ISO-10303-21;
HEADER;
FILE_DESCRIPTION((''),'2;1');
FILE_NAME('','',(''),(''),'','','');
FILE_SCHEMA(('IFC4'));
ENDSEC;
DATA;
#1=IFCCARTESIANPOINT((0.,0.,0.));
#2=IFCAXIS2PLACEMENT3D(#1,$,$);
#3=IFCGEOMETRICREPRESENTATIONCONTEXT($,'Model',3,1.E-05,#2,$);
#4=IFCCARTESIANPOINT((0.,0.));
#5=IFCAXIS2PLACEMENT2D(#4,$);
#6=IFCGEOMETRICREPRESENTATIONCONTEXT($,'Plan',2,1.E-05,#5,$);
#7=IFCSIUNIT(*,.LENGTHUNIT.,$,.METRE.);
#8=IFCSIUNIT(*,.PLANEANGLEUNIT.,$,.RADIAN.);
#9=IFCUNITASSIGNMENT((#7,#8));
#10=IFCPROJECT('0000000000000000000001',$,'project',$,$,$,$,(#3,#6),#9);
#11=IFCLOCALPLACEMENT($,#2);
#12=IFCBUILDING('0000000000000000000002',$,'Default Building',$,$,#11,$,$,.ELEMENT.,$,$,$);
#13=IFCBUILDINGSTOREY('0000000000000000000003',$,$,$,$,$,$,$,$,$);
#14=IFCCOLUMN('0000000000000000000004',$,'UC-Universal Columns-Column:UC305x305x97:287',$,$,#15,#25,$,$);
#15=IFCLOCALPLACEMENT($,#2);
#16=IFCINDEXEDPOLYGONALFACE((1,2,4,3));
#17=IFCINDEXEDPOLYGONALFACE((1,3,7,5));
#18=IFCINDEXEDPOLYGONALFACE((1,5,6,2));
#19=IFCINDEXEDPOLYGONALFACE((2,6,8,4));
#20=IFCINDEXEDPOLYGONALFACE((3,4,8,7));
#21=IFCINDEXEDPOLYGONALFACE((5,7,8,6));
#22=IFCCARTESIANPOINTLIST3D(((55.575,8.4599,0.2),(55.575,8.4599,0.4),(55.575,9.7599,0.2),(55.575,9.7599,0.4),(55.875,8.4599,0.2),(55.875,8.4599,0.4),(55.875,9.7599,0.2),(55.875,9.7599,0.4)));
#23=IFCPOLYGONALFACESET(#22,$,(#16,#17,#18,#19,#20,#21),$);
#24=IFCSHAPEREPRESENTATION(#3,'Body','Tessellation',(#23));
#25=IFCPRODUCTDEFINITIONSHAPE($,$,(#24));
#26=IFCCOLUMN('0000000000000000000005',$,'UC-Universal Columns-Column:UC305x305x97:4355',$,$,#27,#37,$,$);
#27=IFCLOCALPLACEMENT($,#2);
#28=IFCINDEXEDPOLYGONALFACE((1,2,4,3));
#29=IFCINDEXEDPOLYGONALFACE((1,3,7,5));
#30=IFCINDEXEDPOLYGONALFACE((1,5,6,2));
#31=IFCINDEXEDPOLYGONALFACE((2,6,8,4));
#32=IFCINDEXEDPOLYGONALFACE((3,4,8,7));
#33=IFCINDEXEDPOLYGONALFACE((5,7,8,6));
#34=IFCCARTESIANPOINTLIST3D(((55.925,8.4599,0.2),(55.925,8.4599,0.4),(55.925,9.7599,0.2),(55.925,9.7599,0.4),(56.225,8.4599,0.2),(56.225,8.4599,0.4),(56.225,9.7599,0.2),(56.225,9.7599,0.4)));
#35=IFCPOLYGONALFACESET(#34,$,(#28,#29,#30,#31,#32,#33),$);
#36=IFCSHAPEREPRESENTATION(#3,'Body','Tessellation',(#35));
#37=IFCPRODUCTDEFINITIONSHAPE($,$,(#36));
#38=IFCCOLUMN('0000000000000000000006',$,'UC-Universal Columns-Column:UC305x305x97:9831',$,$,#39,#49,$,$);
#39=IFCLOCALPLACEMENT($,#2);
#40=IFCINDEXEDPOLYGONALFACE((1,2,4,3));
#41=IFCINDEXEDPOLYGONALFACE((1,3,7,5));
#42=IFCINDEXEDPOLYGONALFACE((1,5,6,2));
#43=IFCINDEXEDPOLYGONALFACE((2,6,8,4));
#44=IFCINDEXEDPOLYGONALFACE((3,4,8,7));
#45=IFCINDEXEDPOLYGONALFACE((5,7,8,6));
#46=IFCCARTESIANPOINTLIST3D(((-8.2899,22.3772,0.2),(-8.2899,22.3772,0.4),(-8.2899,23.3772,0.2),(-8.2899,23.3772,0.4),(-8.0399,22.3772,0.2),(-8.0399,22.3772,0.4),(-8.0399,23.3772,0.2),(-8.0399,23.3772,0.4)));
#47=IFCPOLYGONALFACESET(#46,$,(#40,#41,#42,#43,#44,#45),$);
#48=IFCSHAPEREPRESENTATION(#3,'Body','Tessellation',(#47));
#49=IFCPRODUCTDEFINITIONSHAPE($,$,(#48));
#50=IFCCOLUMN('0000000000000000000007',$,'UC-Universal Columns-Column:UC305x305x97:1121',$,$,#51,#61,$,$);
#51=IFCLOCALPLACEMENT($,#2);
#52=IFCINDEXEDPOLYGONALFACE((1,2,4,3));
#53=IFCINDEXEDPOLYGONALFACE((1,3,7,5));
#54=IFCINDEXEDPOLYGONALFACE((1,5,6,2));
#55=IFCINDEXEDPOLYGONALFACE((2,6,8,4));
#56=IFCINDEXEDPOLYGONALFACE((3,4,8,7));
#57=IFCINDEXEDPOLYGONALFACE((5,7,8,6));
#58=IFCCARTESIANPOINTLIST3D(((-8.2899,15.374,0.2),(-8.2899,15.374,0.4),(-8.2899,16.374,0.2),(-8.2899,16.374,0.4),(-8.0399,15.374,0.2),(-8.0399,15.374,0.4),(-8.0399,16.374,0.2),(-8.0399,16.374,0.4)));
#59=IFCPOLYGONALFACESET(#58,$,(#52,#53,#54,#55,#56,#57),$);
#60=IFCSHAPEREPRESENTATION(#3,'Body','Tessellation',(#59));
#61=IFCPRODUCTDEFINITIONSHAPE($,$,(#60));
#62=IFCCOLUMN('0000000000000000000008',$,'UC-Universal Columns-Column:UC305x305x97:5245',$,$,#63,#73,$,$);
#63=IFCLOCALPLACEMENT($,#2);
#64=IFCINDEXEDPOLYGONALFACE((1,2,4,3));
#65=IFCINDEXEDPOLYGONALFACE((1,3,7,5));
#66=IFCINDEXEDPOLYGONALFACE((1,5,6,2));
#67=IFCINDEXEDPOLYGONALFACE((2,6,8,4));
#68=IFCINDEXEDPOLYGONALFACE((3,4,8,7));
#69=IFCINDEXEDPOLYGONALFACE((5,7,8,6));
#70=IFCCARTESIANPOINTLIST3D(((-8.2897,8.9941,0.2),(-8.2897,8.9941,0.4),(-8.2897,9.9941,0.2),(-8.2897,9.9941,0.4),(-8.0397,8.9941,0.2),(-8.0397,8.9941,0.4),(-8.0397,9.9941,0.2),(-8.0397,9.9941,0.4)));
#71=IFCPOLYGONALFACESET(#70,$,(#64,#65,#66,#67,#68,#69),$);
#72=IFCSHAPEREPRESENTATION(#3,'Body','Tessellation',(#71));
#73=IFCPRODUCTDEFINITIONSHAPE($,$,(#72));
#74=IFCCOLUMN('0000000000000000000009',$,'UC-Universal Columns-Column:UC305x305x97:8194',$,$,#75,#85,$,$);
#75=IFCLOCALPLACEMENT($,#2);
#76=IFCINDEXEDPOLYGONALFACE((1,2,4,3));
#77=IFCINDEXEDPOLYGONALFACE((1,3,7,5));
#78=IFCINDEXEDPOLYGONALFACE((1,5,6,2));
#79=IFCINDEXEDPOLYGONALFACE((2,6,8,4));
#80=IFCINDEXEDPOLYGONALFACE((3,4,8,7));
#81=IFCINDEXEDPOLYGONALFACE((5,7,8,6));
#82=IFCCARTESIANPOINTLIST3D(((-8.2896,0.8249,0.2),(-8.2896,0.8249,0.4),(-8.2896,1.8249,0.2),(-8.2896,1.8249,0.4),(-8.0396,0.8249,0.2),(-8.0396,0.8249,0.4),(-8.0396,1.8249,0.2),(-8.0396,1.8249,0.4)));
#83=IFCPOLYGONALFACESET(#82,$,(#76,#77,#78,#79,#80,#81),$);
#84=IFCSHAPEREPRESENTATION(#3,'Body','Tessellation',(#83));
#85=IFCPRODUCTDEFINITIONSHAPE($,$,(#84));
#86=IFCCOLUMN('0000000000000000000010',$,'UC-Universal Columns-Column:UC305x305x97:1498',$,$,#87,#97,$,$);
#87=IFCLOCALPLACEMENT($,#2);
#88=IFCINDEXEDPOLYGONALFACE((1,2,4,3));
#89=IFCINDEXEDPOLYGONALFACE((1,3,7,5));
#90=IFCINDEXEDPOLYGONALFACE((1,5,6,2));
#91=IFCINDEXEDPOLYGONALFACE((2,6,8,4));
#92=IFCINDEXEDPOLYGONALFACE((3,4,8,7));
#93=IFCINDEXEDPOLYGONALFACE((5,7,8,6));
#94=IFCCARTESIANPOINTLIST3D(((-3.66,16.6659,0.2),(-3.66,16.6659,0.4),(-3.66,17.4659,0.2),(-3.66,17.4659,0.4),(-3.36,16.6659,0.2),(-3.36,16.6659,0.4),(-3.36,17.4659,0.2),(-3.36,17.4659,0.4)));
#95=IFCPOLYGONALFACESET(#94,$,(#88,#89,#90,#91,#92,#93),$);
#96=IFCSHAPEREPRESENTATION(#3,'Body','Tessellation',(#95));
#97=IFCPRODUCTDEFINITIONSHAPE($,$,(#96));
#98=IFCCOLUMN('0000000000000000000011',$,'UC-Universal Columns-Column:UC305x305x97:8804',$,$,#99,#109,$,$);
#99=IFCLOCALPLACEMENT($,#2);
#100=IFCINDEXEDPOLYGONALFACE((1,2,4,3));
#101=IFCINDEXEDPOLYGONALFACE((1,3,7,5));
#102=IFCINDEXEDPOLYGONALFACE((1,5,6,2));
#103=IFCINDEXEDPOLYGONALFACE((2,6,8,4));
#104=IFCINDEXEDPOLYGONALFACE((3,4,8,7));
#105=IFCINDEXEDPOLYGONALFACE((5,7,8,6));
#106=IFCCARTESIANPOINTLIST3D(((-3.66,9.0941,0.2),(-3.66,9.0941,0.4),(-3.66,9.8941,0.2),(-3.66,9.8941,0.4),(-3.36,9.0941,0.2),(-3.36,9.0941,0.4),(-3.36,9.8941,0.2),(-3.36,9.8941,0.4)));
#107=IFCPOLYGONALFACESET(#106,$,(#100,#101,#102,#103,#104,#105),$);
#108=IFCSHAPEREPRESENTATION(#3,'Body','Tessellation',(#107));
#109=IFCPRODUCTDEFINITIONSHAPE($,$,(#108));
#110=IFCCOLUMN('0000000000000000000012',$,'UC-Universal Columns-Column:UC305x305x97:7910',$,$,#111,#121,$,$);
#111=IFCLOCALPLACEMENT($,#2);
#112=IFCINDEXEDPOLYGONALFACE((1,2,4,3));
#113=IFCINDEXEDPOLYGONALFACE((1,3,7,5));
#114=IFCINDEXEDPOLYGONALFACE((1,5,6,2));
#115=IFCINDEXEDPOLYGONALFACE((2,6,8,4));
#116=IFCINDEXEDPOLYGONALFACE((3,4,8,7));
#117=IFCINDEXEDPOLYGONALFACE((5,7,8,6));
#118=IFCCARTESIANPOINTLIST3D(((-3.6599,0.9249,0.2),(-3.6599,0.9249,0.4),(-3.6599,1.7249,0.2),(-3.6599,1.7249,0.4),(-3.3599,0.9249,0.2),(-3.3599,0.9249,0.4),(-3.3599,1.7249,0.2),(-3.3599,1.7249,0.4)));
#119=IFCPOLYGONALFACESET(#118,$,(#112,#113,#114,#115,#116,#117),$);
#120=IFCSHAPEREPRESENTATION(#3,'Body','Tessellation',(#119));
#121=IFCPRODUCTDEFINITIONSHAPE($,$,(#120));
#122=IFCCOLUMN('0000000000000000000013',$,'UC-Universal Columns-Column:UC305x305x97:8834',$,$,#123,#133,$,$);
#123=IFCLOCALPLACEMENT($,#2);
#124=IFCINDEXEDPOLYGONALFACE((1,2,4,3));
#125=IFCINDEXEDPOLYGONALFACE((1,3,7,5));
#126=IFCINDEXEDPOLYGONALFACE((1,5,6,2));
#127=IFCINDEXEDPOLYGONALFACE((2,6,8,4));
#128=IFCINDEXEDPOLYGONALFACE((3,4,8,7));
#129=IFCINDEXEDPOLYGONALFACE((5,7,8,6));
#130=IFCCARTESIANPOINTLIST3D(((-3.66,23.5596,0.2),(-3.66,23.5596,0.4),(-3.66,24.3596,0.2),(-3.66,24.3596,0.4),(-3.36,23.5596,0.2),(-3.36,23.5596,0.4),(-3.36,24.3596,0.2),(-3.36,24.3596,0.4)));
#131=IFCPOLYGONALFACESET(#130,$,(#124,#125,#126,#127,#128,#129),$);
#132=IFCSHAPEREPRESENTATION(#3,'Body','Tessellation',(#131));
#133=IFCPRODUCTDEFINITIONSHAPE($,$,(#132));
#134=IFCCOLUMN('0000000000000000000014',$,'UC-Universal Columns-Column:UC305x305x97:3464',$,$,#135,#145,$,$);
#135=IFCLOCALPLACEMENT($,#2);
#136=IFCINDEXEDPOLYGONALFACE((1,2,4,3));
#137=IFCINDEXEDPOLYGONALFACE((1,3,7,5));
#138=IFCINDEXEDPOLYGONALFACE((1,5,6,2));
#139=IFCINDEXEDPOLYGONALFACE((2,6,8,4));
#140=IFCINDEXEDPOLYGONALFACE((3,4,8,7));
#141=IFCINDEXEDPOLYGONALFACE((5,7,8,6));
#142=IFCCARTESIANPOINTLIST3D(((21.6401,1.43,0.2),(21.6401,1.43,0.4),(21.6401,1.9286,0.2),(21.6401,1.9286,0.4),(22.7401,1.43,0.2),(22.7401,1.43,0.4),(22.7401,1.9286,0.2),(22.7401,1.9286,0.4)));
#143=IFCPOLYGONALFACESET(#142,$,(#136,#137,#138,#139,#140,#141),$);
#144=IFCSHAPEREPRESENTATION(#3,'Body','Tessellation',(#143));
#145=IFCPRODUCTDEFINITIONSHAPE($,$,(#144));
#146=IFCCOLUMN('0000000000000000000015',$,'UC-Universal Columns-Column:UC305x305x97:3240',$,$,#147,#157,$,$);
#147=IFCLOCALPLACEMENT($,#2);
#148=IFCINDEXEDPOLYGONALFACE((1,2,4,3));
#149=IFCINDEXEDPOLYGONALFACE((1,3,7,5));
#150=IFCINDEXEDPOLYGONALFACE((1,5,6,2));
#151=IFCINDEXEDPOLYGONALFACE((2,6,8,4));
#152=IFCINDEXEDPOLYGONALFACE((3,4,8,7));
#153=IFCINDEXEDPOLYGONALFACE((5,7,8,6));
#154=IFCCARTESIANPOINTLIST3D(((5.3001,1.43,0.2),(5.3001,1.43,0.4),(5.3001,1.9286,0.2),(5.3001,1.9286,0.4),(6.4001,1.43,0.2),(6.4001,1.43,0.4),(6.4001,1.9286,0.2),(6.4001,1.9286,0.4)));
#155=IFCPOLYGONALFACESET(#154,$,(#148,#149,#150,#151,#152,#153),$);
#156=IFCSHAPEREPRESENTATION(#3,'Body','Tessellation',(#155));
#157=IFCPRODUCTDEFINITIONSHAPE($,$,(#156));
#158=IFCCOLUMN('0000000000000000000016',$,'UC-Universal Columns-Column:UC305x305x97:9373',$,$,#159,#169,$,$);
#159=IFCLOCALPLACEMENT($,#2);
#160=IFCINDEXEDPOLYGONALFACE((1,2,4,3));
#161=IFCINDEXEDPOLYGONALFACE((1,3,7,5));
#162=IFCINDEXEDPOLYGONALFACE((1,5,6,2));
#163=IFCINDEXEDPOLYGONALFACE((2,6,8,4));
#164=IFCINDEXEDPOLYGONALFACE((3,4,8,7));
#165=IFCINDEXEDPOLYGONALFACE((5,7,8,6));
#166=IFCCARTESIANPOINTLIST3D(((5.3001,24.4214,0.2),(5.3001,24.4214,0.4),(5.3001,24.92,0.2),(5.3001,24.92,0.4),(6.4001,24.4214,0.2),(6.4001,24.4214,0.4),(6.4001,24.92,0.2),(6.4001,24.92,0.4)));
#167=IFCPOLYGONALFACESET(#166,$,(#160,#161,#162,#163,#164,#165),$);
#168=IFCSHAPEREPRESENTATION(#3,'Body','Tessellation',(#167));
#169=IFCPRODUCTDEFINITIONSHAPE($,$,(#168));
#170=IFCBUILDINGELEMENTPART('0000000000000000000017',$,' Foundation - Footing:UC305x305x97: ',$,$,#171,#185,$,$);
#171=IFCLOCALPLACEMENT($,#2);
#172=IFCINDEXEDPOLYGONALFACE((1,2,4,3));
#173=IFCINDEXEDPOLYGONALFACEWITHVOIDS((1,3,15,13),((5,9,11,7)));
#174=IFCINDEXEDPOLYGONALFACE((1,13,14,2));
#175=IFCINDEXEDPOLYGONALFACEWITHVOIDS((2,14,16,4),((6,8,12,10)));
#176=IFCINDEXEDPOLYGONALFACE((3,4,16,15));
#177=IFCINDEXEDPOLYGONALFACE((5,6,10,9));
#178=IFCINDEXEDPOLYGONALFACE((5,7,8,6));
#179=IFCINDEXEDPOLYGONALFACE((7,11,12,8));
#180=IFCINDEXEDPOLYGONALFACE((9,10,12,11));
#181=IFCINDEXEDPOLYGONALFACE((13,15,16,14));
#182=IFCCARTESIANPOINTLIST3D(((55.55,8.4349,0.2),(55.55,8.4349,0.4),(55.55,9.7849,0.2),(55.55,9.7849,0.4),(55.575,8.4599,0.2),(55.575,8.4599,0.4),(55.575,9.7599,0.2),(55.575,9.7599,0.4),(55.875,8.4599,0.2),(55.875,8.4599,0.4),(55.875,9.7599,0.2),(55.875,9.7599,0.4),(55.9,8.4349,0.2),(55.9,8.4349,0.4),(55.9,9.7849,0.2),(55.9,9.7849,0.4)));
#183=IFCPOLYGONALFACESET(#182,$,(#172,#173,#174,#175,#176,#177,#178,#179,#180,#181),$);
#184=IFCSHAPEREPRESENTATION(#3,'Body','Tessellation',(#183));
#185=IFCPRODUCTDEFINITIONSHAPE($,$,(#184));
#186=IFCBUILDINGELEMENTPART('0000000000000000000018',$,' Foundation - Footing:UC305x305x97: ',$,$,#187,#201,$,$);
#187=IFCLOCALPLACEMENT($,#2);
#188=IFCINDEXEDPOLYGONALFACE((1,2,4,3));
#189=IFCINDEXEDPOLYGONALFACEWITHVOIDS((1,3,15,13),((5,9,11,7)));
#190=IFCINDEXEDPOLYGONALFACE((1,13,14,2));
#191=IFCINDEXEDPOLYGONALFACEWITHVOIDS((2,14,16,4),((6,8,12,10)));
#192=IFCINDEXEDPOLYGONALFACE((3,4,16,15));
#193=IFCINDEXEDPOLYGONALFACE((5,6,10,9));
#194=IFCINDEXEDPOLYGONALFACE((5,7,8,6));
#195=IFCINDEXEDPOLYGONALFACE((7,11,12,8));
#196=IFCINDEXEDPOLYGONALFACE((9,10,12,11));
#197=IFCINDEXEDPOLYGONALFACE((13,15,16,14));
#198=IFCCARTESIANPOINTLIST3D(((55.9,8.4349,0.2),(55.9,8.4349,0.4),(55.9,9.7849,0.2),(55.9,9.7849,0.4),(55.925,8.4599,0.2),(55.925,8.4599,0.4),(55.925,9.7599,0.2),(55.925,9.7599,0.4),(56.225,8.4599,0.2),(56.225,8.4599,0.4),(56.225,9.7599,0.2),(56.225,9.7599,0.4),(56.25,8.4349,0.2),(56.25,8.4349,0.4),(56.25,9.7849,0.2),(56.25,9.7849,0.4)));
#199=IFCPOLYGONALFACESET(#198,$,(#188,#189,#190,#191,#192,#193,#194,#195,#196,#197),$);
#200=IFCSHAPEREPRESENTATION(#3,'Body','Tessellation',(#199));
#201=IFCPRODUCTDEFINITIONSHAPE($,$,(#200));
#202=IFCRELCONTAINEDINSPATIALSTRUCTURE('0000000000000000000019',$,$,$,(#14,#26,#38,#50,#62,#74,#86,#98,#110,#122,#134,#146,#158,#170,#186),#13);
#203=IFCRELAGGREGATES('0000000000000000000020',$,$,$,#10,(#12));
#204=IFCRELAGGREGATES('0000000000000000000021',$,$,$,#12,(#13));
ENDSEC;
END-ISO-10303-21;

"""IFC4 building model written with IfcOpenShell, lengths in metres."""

from ifc_helpers import new_model, si_unit, origin, origin_2d, place, context, project, spatial, polyline, outline, extrude, element, save


model = new_model("IFC4")

# Units and contexts
model_context = context("Model", 3, precision=1e-05, world=origin())
plan_context = context("Plan", 2, precision=1e-05, world=origin_2d())
ifc_project = project(units=[si_unit("LENGTHUNIT", "METRE"), si_unit("PLANEANGLEUNIT", "RADIAN")], contexts=[model_context, plan_context])

# Building, storey
building_placement = place(None, origin())
building = spatial("IfcBuilding", under=ifc_project, at=building_placement, Name="Default Building", CompositionType="ELEMENT")
storey = spatial("IfcBuildingStorey", under=building)

# Columns
element("IfcColumn", 1, inside=storey, Name="UC-Universal Columns-Column:UC305x305x97:287", context=model_context, shape_type="SweptSolid", body=[
    extrude(outline(polyline([(55.575, 9.7599, 0.2), (55.575, 8.4599, 0.2), (55.875, 8.4599, 0.2), (55.875, 9.7599, 0.2), (55.575, 9.7599, 0.2)])), None, (0.0, 0.0, 1.0), 0.2),
])
element("IfcColumn", 2, inside=storey, Name="UC-Universal Columns-Column:UC305x305x97:4355", context=model_context, shape_type="SweptSolid", body=[
    extrude(outline(polyline([(55.925, 9.7599, 0.2), (55.925, 8.4599, 0.2), (56.225, 8.4599, 0.2), (56.225, 9.7599, 0.2), (55.925, 9.7599, 0.2)])), None, (0.0, 0.0, 1.0), 0.2),
])
element("IfcColumn", 3, inside=storey, Name="UC-Universal Columns-Column:UC305x305x97:9831", context=model_context, shape_type="SweptSolid", body=[
    extrude(outline(polyline([(-8.0399, 23.3772, 0.2), (-8.2899, 23.3772, 0.2), (-8.2899, 22.3772, 0.2), (-8.0399, 22.3772, 0.2), (-8.0399, 23.3772, 0.2)])), None, (0.0, 0.0, 1.0), 0.2),
])
element("IfcColumn", 4, inside=storey, Name="UC-Universal Columns-Column:UC305x305x97:1121", context=model_context, shape_type="SweptSolid", body=[
    extrude(outline(polyline([(-8.0399, 16.374, 0.2), (-8.2899, 16.374, 0.2), (-8.2899, 15.374, 0.2), (-8.0399, 15.374, 0.2), (-8.0399, 16.374, 0.2)])), None, (0.0, 0.0, 1.0), 0.2),
])
element("IfcColumn", 5, inside=storey, Name="UC-Universal Columns-Column:UC305x305x97:5245", context=model_context, shape_type="SweptSolid", body=[
    extrude(outline(polyline([(-8.0397, 9.9941, 0.2), (-8.2897, 9.9941, 0.2), (-8.2897, 8.9941, 0.2), (-8.0397, 8.9941, 0.2), (-8.0397, 9.9941, 0.2)])), None, (0.0, 0.0, 1.0), 0.2),
])
element("IfcColumn", 6, inside=storey, Name="UC-Universal Columns-Column:UC305x305x97:8194", context=model_context, shape_type="SweptSolid", body=[
    extrude(outline(polyline([(-8.0396, 1.8249, 0.2), (-8.2896, 1.8249, 0.2), (-8.2896, 0.8249, 0.2), (-8.0396, 0.8249, 0.2), (-8.0396, 1.8249, 0.2)])), None, (0.0, 0.0, 1.0), 0.2),
])
element("IfcColumn", 7, inside=storey, Name="UC-Universal Columns-Column:UC305x305x97:1498", context=model_context, shape_type="SweptSolid", body=[
    extrude(outline(polyline([(-3.36, 17.4659, 0.2), (-3.66, 17.4659, 0.2), (-3.66, 16.6659, 0.2), (-3.36, 16.6659, 0.2), (-3.36, 17.4659, 0.2)])), None, (0.0, 0.0, 1.0), 0.2),
])
element("IfcColumn", 8, inside=storey, Name="UC-Universal Columns-Column:UC305x305x97:8804", context=model_context, shape_type="SweptSolid", body=[
    extrude(outline(polyline([(-3.36, 9.8941, 0.2), (-3.66, 9.8941, 0.2), (-3.66, 9.0941, 0.2), (-3.36, 9.0941, 0.2), (-3.36, 9.8941, 0.2)])), None, (0.0, 0.0, 1.0), 0.2),
])
element("IfcColumn", 9, inside=storey, Name="UC-Universal Columns-Column:UC305x305x97:7910", context=model_context, shape_type="SweptSolid", body=[
    extrude(outline(polyline([(-3.3599, 1.7249, 0.2), (-3.6599, 1.7249, 0.2), (-3.6599, 0.9249, 0.2), (-3.3599, 0.9249, 0.2), (-3.3599, 1.7249, 0.2)])), None, (0.0, 0.0, 1.0), 0.2),
])
element("IfcColumn", 10, inside=storey, Name="UC-Universal Columns-Column:UC305x305x97:8834", context=model_context, shape_type="SweptSolid", body=[
    extrude(outline(polyline([(-3.66, 23.5596, 0.2), (-3.36, 23.5596, 0.2), (-3.36, 24.3596, 0.2), (-3.66, 24.3596, 0.2), (-3.66, 23.5596, 0.2)])), None, (0.0, 0.0, 1.0), 0.2),
])
element("IfcColumn", 11, inside=storey, Name="UC-Universal Columns-Column:UC305x305x97:3464", context=model_context, shape_type="SweptSolid", body=[
    extrude(outline(polyline([(21.6401, 1.43, 0.2), (22.7401, 1.43, 0.2), (22.7401, 1.9286, 0.2), (21.6401, 1.9286, 0.2), (21.6401, 1.43, 0.2)])), None, (0.0, 0.0, 1.0), 0.2),
])
element("IfcColumn", 12, inside=storey, Name="UC-Universal Columns-Column:UC305x305x97:3240", context=model_context, shape_type="SweptSolid", body=[
    extrude(outline(polyline([(5.3001, 1.43, 0.2), (6.4001, 1.43, 0.2), (6.4001, 1.9286, 0.2), (5.3001, 1.9286, 0.2), (5.3001, 1.43, 0.2)])), None, (0.0, 0.0, 1.0), 0.2),
])
element("IfcColumn", 13, inside=storey, Name="UC-Universal Columns-Column:UC305x305x97:9373", context=model_context, shape_type="SweptSolid", body=[
    extrude(outline(polyline([(5.3001, 24.4214, 0.2), (6.4001, 24.4214, 0.2), (6.4001, 24.92, 0.2), (5.3001, 24.92, 0.2), (5.3001, 24.4214, 0.2)])), None, (0.0, 0.0, 1.0), 0.2),
])

# Building element parts, openings
building_element_part_1 = element("IfcBuildingElementPart", 14, inside=storey, Name=" Foundation - Footing:UC305x305x97: ", context=model_context, shape_type="SweptSolid", body=[
    extrude(outline(polyline([(55.55, 9.7849, 0.2), (55.55, 8.4349, 0.2), (55.9, 8.4349, 0.2), (55.9, 9.7849, 0.2), (55.55, 9.7849, 0.2)])), None, (0.0, 0.0, 1.0), 0.2),
])
element("IfcOpeningElement", 15, inside=storey, cuts=building_element_part_1, context=model_context, shape_type="SweptSolid", body=[
    extrude(outline(polyline([(55.575, 9.7599, 0.2), (55.575, 8.4599, 0.2), (55.875, 8.4599, 0.2), (55.875, 9.7599, 0.2), (55.575, 9.7599, 0.2)])), None, (0.0, 0.0, 1.0), 0.2),
])
building_element_part_2 = element("IfcBuildingElementPart", 16, inside=storey, Name=" Foundation - Footing:UC305x305x97: ", context=model_context, shape_type="SweptSolid", body=[
    extrude(outline(polyline([(55.9, 9.7849, 0.2), (55.9, 8.4349, 0.2), (56.25, 8.4349, 0.2), (56.25, 9.7849, 0.2), (55.9, 9.7849, 0.2)])), None, (0.0, 0.0, 1.0), 0.2),
])
element("IfcOpeningElement", 17, inside=storey, cuts=building_element_part_2, context=model_context, shape_type="SweptSolid", body=[
    extrude(outline(polyline([(55.925, 9.7599, 0.2), (55.925, 8.4599, 0.2), (56.225, 8.4599, 0.2), (56.225, 9.7599, 0.2), (55.925, 9.7599, 0.2)])), None, (0.0, 0.0, 1.0), 0.2),
])

save(model, "model.ifc")
